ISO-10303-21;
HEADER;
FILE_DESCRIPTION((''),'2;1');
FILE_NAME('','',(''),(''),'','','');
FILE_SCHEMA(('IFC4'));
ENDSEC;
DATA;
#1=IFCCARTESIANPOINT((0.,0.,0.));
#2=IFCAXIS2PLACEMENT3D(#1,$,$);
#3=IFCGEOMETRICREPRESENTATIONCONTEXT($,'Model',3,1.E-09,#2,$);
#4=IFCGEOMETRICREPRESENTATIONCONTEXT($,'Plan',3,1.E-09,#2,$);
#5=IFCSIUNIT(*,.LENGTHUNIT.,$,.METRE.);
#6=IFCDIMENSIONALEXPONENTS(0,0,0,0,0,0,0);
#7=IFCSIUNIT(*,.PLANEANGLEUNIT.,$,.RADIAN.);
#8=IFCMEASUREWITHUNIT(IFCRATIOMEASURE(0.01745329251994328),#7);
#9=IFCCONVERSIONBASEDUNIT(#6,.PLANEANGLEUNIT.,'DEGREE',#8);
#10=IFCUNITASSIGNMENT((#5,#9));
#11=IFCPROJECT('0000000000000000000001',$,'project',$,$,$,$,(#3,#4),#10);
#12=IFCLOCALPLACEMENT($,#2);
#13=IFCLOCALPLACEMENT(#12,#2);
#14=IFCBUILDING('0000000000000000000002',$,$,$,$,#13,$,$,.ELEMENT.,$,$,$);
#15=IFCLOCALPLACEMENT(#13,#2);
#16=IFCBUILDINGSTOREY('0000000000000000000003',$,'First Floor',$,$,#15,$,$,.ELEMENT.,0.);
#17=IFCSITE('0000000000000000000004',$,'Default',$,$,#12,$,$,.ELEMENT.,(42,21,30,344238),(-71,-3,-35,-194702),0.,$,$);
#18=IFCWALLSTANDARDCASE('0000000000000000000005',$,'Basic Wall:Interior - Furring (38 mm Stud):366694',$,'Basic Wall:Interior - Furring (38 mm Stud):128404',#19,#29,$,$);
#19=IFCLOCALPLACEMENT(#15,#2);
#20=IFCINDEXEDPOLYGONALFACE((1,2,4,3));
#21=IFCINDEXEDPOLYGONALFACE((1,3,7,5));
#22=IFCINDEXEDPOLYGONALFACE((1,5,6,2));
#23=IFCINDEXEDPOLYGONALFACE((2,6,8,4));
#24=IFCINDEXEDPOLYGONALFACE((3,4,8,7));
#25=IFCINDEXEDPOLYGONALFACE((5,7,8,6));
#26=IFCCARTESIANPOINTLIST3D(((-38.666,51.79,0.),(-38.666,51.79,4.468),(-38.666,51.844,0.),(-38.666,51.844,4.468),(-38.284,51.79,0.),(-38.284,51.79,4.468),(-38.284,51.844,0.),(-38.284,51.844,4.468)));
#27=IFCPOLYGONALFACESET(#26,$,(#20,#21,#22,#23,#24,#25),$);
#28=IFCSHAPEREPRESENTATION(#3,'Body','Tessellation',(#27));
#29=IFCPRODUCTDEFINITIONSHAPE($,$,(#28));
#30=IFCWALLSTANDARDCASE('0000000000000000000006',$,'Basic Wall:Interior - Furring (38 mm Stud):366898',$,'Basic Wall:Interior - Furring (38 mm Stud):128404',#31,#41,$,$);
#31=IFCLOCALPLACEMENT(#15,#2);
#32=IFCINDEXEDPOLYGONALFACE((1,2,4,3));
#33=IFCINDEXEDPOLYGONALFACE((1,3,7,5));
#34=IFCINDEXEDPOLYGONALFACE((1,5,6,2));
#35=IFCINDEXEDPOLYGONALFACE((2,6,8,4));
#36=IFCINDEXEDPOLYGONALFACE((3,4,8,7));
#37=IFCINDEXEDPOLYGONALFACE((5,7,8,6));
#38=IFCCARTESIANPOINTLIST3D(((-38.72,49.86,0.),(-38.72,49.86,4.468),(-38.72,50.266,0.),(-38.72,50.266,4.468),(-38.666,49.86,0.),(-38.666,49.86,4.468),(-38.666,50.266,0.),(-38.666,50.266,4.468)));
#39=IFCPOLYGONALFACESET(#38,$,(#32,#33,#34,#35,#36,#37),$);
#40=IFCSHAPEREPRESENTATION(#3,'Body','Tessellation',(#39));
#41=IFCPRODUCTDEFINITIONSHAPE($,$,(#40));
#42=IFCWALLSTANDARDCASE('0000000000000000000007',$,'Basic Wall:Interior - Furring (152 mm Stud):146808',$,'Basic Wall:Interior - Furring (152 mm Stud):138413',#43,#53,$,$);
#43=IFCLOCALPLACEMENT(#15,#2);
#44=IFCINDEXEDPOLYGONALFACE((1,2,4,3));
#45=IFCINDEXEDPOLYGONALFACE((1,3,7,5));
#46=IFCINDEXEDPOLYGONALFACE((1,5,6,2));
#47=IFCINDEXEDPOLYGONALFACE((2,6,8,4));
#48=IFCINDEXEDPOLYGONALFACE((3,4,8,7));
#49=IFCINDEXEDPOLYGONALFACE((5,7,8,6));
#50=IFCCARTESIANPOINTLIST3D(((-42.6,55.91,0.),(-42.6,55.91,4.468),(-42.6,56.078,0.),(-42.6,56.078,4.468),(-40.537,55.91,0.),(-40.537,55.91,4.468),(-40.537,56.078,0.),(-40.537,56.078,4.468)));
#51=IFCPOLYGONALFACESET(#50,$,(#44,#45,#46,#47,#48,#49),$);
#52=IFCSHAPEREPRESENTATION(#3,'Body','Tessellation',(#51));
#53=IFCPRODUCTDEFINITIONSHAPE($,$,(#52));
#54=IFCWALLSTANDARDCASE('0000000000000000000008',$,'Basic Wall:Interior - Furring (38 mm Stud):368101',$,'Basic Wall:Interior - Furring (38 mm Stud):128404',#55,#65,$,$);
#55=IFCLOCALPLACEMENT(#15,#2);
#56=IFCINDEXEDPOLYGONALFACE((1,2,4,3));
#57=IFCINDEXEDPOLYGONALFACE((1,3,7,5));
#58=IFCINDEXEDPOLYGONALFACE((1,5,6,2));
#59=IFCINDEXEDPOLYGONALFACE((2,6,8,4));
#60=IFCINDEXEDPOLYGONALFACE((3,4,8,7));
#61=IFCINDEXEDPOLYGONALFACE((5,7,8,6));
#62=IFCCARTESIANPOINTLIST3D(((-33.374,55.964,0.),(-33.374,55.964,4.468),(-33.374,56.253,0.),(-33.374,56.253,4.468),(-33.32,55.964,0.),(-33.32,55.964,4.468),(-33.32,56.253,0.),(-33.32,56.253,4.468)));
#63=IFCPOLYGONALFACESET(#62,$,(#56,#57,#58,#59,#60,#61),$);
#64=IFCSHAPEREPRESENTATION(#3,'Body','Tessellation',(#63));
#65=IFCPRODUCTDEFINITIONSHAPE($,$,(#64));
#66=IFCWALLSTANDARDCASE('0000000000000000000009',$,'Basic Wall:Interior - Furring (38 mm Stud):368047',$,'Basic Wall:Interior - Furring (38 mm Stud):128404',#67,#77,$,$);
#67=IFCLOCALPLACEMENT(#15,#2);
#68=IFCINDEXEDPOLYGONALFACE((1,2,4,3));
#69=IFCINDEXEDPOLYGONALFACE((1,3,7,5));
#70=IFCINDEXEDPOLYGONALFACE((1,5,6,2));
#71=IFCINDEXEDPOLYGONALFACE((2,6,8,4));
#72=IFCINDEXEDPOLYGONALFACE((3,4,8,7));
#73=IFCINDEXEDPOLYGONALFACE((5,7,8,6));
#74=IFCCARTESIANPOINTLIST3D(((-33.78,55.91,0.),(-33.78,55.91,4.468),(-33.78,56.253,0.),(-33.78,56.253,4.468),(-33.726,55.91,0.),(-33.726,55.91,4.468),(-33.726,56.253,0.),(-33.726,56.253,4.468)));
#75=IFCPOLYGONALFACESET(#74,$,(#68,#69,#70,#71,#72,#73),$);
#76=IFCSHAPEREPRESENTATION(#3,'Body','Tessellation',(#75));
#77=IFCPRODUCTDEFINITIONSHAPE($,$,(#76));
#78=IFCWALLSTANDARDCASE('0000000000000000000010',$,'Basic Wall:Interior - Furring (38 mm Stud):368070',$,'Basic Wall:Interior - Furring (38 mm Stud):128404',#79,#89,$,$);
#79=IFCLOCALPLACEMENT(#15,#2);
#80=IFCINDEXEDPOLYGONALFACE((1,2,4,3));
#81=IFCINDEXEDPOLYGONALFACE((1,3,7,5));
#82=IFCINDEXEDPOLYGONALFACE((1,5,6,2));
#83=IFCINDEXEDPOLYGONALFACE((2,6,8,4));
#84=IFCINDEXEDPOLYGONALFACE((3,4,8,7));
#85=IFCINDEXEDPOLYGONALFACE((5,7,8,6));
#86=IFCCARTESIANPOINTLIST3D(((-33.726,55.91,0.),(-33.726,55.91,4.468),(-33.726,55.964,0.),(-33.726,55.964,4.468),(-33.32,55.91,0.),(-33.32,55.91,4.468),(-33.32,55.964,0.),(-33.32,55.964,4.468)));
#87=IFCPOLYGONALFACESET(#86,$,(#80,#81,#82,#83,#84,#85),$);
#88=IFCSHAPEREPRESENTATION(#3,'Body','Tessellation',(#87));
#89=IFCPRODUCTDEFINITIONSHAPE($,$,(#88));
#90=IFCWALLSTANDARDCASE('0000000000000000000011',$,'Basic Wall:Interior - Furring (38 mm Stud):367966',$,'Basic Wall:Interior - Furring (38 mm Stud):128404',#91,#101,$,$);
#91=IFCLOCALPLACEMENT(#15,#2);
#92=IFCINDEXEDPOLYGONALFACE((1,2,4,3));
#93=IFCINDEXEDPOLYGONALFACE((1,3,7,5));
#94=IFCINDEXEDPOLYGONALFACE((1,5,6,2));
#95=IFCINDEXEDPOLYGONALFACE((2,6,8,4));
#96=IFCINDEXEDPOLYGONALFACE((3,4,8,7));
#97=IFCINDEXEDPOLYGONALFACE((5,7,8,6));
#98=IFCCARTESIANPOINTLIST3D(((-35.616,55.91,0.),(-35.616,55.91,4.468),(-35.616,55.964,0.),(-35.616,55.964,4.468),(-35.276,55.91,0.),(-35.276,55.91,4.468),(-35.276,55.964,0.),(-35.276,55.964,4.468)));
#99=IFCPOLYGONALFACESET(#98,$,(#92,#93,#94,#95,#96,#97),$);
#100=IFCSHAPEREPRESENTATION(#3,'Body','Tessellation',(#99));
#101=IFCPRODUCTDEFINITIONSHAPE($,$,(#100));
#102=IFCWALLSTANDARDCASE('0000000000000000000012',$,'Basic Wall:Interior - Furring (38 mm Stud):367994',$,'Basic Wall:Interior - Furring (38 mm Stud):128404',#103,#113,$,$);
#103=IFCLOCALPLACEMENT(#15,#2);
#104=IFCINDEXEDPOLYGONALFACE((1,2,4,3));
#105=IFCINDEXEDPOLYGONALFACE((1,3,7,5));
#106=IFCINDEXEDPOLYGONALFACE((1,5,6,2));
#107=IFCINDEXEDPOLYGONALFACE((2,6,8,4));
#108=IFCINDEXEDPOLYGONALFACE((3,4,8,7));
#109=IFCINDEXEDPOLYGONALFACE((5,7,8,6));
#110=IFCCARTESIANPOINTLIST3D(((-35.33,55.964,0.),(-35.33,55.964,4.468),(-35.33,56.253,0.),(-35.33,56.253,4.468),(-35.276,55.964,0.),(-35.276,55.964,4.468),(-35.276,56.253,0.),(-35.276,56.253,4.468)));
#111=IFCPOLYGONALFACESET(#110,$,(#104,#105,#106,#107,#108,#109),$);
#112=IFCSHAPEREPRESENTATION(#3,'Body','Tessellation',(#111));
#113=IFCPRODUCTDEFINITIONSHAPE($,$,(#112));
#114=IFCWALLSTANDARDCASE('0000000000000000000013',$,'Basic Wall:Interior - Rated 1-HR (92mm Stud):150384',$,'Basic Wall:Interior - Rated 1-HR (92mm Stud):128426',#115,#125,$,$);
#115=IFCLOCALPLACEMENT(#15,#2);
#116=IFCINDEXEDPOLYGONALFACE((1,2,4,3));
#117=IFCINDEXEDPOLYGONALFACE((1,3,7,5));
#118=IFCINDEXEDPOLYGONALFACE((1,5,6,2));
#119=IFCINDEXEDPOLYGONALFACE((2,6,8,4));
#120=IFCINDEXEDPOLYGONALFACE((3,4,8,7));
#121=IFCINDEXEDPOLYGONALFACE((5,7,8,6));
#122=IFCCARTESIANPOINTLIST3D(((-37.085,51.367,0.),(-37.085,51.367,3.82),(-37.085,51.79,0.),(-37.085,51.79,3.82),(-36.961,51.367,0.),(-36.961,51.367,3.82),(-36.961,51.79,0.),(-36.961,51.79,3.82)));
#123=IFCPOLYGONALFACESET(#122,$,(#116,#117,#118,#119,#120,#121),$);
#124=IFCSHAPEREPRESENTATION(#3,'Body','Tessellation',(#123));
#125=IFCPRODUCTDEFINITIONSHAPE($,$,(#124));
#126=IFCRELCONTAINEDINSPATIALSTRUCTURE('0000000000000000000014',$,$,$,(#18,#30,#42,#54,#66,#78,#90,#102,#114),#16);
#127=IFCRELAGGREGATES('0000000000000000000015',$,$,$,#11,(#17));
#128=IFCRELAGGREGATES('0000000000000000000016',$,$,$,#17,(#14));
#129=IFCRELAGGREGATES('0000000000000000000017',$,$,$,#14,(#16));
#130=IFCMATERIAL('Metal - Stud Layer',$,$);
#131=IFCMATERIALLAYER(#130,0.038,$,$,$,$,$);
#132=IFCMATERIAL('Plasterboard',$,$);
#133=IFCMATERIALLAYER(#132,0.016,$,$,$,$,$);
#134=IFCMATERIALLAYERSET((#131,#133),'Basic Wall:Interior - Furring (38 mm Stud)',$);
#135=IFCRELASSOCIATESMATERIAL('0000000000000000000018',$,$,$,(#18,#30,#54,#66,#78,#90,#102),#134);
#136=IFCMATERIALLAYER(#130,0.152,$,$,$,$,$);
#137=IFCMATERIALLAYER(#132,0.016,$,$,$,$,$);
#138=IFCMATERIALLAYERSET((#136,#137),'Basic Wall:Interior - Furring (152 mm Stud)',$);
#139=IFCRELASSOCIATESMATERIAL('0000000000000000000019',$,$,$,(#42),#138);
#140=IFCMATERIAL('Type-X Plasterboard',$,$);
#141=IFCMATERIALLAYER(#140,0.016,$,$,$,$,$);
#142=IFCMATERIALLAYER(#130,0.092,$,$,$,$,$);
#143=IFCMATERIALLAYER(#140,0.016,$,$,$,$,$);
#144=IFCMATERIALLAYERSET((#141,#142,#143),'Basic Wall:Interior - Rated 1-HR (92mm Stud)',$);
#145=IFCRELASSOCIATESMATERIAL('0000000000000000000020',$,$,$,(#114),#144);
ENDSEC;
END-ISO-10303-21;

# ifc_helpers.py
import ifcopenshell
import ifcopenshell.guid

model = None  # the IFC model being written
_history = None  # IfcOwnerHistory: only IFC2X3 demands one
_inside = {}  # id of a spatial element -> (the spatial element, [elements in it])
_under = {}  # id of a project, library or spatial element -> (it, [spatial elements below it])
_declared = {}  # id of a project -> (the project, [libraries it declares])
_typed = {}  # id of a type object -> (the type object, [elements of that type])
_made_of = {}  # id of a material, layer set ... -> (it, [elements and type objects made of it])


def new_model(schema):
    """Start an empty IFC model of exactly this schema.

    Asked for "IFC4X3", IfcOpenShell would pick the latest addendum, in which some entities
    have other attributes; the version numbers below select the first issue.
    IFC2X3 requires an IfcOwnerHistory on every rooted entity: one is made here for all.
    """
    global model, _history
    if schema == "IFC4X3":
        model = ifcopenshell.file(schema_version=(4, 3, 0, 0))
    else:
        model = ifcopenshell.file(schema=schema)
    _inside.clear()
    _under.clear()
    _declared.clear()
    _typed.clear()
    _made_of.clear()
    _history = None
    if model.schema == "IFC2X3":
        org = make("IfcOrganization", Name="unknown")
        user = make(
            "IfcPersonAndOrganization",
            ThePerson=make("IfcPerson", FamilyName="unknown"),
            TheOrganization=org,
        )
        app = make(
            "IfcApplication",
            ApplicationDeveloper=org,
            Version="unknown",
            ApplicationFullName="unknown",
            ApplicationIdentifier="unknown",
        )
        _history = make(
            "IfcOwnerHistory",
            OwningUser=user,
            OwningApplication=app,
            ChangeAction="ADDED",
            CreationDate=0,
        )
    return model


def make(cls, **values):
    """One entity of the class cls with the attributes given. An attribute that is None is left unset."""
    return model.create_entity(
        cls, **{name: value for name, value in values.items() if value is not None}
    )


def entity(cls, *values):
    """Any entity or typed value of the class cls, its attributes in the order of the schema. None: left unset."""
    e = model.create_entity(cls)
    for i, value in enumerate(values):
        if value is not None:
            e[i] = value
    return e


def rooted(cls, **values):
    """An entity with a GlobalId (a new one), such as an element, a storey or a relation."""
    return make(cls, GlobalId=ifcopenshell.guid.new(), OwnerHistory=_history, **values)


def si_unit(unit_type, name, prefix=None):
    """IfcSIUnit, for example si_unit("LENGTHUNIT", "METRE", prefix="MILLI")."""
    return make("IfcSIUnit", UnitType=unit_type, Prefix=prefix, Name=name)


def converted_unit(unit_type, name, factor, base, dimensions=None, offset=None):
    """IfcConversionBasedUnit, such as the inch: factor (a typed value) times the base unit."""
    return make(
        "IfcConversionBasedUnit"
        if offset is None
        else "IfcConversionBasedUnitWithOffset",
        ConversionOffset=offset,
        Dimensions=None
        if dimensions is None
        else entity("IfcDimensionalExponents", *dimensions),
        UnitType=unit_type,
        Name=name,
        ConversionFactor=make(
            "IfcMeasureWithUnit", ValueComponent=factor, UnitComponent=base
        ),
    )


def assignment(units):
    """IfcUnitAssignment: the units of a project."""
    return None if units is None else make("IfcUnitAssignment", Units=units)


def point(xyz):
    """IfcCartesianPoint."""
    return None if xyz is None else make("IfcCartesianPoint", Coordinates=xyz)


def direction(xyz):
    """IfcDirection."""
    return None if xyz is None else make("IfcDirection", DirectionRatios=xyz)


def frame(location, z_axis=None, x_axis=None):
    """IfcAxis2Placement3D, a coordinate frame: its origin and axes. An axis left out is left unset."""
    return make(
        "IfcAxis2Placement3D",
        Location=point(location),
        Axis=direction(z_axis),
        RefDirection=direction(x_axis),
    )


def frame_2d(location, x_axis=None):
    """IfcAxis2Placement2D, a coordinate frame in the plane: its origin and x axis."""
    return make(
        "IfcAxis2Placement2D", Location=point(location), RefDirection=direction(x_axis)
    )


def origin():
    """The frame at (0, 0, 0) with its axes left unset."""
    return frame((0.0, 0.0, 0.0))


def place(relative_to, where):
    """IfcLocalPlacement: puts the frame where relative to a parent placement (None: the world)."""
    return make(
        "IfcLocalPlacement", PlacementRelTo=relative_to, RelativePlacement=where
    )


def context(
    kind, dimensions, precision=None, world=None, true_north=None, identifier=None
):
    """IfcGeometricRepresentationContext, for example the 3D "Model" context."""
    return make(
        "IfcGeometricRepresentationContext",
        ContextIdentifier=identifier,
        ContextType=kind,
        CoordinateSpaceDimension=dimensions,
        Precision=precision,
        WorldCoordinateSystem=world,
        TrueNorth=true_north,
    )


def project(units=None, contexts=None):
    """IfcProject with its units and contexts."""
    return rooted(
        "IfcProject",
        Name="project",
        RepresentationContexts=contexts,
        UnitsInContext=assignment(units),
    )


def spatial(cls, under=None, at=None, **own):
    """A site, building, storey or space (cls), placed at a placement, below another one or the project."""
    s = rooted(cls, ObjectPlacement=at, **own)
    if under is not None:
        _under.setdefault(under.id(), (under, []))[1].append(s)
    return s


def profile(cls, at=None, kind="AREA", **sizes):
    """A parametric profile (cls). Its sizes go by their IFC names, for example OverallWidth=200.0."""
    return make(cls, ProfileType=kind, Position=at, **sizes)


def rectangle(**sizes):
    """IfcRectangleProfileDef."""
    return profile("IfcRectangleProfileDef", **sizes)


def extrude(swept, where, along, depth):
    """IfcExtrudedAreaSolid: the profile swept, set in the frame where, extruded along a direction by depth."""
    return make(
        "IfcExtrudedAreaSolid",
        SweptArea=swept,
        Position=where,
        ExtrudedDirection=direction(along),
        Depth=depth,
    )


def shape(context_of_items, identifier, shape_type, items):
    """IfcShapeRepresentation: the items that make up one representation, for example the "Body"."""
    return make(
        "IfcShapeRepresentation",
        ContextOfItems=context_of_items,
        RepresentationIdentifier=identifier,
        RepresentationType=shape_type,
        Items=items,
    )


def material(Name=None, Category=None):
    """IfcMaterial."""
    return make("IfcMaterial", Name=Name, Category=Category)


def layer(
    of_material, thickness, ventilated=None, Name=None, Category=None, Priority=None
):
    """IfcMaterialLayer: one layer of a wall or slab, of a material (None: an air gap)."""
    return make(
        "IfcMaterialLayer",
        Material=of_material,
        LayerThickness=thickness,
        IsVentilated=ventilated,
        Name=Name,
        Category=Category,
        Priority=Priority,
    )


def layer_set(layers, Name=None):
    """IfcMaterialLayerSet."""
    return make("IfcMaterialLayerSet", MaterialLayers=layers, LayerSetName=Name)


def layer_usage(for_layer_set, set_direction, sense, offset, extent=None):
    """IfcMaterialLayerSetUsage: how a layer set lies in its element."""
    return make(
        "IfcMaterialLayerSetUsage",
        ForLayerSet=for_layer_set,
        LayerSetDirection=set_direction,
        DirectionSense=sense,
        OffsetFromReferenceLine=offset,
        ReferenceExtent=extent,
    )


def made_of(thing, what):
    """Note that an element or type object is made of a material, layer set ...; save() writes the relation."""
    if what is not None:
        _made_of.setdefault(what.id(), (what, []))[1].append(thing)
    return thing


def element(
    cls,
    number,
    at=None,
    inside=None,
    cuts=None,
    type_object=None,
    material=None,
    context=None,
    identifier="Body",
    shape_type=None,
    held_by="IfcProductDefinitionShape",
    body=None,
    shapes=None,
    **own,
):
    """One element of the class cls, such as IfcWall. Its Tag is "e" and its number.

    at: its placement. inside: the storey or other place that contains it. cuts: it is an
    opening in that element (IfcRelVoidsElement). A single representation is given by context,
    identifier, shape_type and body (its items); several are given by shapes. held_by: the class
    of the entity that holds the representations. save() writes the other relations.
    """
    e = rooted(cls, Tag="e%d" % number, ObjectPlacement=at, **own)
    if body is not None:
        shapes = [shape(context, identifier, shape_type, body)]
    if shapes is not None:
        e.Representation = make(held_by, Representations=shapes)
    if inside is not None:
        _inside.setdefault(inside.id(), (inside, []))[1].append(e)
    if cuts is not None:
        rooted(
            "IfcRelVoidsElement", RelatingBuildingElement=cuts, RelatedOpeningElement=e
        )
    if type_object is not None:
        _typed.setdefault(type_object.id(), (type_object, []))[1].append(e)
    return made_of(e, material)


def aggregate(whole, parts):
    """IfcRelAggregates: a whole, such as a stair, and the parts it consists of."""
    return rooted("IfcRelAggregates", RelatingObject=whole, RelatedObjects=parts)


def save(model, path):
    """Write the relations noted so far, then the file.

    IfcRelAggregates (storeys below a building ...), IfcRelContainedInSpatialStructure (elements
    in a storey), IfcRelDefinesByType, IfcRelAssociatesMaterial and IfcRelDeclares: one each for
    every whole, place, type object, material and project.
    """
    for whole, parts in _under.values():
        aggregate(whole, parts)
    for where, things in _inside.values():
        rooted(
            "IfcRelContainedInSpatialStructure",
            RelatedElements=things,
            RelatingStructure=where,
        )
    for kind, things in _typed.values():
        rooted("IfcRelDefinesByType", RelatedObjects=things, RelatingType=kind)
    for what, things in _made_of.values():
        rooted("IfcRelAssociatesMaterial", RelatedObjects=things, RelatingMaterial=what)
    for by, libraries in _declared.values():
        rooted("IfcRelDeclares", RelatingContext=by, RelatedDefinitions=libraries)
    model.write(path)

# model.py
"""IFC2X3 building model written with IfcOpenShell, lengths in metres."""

from ifc_helpers import new_model, entity, si_unit, converted_unit, frame, frame_2d, origin, place, context, project, spatial, rectangle, extrude, material, layer, layer_set, layer_usage, element, save


model = new_model("IFC2X3")

# Units and contexts
model_context = context("Model", 3, precision=1e-09, world=origin())
plan_context = context("Plan", 3, precision=1e-09, world=origin())
ifc_project = project(units=[si_unit("LENGTHUNIT", "METRE"), converted_unit("PLANEANGLEUNIT", "DEGREE", entity("IfcRatioMeasure", 0.01745329251994328), si_unit("PLANEANGLEUNIT", "RADIAN"), dimensions=[0, 0, 0, 0, 0, 0, 0])], contexts=[model_context, plan_context])

# Site, building, storey
site_placement = place(None, origin())
site = spatial("IfcSite", under=ifc_project, at=site_placement, Name="Default", CompositionType="ELEMENT", RefLatitude=(42, 21, 30, 344238), RefLongitude=(-71, -3, -35, -194702), RefElevation=0.0)
building_placement = place(site_placement, origin())
building = spatial("IfcBuilding", under=site, at=building_placement, CompositionType="ELEMENT")
storey_placement = place(building_placement, origin())
storey = spatial("IfcBuildingStorey", under=building, at=storey_placement, Name="First Floor", CompositionType="ELEMENT", Elevation=0.0)

# Shared definitions
ifc_material_1 = material(Name="Metal - Stud Layer")
ifc_material_2 = material(Name="Plasterboard")
ifc_material_3 = material(Name="Type-X Plasterboard")
ifc_layer_1 = layer(ifc_material_3, 0.016)
ifc_layer_2 = layer(ifc_material_1, 0.092)
ifc_layer_3 = layer(ifc_material_3, 0.016)
ifc_layer_set_1 = layer_set([ifc_layer_1, ifc_layer_2, ifc_layer_3], Name="Basic Wall:Interior - Rated 1-HR (92mm Stud)")
ifc_layer_usage_1 = layer_usage(ifc_layer_set_1, "AXIS2", "NEGATIVE", 0.062)

# Shared definitions
ifc_layer_4 = layer(ifc_material_1, 0.038)
ifc_layer_5 = layer(ifc_material_2, 0.016)
ifc_layer_set_2 = layer_set([ifc_layer_4, ifc_layer_5], Name="Basic Wall:Interior - Furring (38 mm Stud)")
ifc_layer_usage_2 = layer_usage(ifc_layer_set_2, "AXIS2", "NEGATIVE", 0.027)

# Walls
wall_1_placement = place(storey_placement, frame((-38.666, 51.817, 0.0)))
element("IfcWallStandardCase", 1, at=wall_1_placement, inside=storey, material=ifc_layer_usage_2, Name="Basic Wall:Interior - Furring (38 mm Stud):366694", ObjectType="Basic Wall:Interior - Furring (38 mm Stud):128404", context=model_context, shape_type="SweptSolid", body=[
    extrude(rectangle(XDim=0.382, YDim=0.054, at=frame_2d((0.191, 0.0), x_axis=(-1.0, 0.0))), origin(), (0.0, 0.0, 1.0), 4.468),
])
wall_2_placement = place(storey_placement, frame((-38.693, 50.266, 0.0), z_axis=(0.0, 0.0, 1.0), x_axis=(0.0, -1.0, 0.0)))
element("IfcWallStandardCase", 2, at=wall_2_placement, inside=storey, material=ifc_layer_usage_2, Name="Basic Wall:Interior - Furring (38 mm Stud):366898", ObjectType="Basic Wall:Interior - Furring (38 mm Stud):128404", context=model_context, shape_type="SweptSolid", body=[
    extrude(rectangle(XDim=0.406, YDim=0.054, at=frame_2d((0.203, 0.0), x_axis=(-1.0, 0.0))), origin(), (0.0, 0.0, 1.0), 4.468),
])
ifc_layer_6 = layer(ifc_material_1, 0.152)
ifc_layer_7 = layer(ifc_material_2, 0.016)
ifc_layer_set_3 = layer_set([ifc_layer_6, ifc_layer_7], Name="Basic Wall:Interior - Furring (152 mm Stud)")
ifc_layer_usage_3 = layer_usage(ifc_layer_set_3, "AXIS2", "POSITIVE", -0.084)
wall_3_placement = place(storey_placement, frame((-40.537, 55.994, 0.0), z_axis=(0.0, 0.0, 1.0), x_axis=(-1.0, 0.0, 0.0)))
element("IfcWallStandardCase", 3, at=wall_3_placement, inside=storey, material=ifc_layer_usage_3, Name="Basic Wall:Interior - Furring (152 mm Stud):146808", ObjectType="Basic Wall:Interior - Furring (152 mm Stud):138413", context=model_context, shape_type="SweptSolid", body=[
    extrude(rectangle(XDim=2.063, YDim=0.168, at=frame_2d((1.0315, 0.0), x_axis=(-1.0, 0.0))), origin(), (0.0, 0.0, 1.0), 4.468),
])
wall_4_placement = place(storey_placement, frame((-33.347, 55.964, 0.0), z_axis=(0.0, 0.0, 1.0), x_axis=(0.0, 1.0, 0.0)))
element("IfcWallStandardCase", 4, at=wall_4_placement, inside=storey, material=ifc_layer_usage_2, Name="Basic Wall:Interior - Furring (38 mm Stud):368101", ObjectType="Basic Wall:Interior - Furring (38 mm Stud):128404", context=model_context, shape_type="SweptSolid", body=[
    extrude(rectangle(XDim=0.289, YDim=0.054, at=frame_2d((0.1445, 0.0), x_axis=(-1.0, 0.0))), origin(), (0.0, 0.0, 1.0), 4.468),
])
wall_5_placement = place(storey_placement, frame((-33.753, 56.253, 0.0), z_axis=(0.0, 0.0, 1.0), x_axis=(0.0, -1.0, 0.0)))
element("IfcWallStandardCase", 5, at=wall_5_placement, inside=storey, material=ifc_layer_usage_2, Name="Basic Wall:Interior - Furring (38 mm Stud):368047", ObjectType="Basic Wall:Interior - Furring (38 mm Stud):128404", context=model_context, shape_type="SweptSolid", body=[
    extrude(rectangle(XDim=0.343, YDim=0.054, at=frame_2d((0.1715, 0.0), x_axis=(-1.0, 0.0))), origin(), (0.0, 0.0, 1.0), 4.468),
])
wall_6_placement = place(storey_placement, frame((-33.726, 55.937, 0.0)))
element("IfcWallStandardCase", 6, at=wall_6_placement, inside=storey, material=ifc_layer_usage_2, Name="Basic Wall:Interior - Furring (38 mm Stud):368070", ObjectType="Basic Wall:Interior - Furring (38 mm Stud):128404", context=model_context, shape_type="SweptSolid", body=[
    extrude(rectangle(XDim=0.406, YDim=0.054, at=frame_2d((0.203, 0.0), x_axis=(-1.0, 0.0))), origin(), (0.0, 0.0, 1.0), 4.468),
])
wall_7_placement = place(storey_placement, frame((-35.616, 55.937, 0.0)))
element("IfcWallStandardCase", 7, at=wall_7_placement, inside=storey, material=ifc_layer_usage_2, Name="Basic Wall:Interior - Furring (38 mm Stud):367966", ObjectType="Basic Wall:Interior - Furring (38 mm Stud):128404", context=model_context, shape_type="SweptSolid", body=[
    extrude(rectangle(XDim=0.34, YDim=0.054, at=frame_2d((0.17, 0.0), x_axis=(-1.0, 0.0))), origin(), (0.0, 0.0, 1.0), 4.468),
])
wall_8_placement = place(storey_placement, frame((-35.303, 55.964, 0.0), z_axis=(0.0, 0.0, 1.0), x_axis=(0.0, 1.0, 0.0)))
element("IfcWallStandardCase", 8, at=wall_8_placement, inside=storey, material=ifc_layer_usage_2, Name="Basic Wall:Interior - Furring (38 mm Stud):367994", ObjectType="Basic Wall:Interior - Furring (38 mm Stud):128404", context=model_context, shape_type="SweptSolid", body=[
    extrude(rectangle(XDim=0.289, YDim=0.054, at=frame_2d((0.1445, 0.0), x_axis=(-1.0, 0.0))), origin(), (0.0, 0.0, 1.0), 4.468),
])
wall_9_placement = place(storey_placement, frame((-37.023, 51.367, 0.0), z_axis=(0.0, 0.0, 1.0), x_axis=(0.0, 1.0, 0.0)))
element("IfcWallStandardCase", 9, at=wall_9_placement, inside=storey, material=ifc_layer_usage_1, Name="Basic Wall:Interior - Rated 1-HR (92mm Stud):150384", ObjectType="Basic Wall:Interior - Rated 1-HR (92mm Stud):128426", context=model_context, shape_type="SweptSolid", body=[
    extrude(rectangle(XDim=0.423, YDim=0.124, at=frame_2d((0.2115, 0.0), x_axis=(-1.0, 0.0))), origin(), (0.0, 0.0, 1.0), 3.82),
])

save(model, "model.ifc")
